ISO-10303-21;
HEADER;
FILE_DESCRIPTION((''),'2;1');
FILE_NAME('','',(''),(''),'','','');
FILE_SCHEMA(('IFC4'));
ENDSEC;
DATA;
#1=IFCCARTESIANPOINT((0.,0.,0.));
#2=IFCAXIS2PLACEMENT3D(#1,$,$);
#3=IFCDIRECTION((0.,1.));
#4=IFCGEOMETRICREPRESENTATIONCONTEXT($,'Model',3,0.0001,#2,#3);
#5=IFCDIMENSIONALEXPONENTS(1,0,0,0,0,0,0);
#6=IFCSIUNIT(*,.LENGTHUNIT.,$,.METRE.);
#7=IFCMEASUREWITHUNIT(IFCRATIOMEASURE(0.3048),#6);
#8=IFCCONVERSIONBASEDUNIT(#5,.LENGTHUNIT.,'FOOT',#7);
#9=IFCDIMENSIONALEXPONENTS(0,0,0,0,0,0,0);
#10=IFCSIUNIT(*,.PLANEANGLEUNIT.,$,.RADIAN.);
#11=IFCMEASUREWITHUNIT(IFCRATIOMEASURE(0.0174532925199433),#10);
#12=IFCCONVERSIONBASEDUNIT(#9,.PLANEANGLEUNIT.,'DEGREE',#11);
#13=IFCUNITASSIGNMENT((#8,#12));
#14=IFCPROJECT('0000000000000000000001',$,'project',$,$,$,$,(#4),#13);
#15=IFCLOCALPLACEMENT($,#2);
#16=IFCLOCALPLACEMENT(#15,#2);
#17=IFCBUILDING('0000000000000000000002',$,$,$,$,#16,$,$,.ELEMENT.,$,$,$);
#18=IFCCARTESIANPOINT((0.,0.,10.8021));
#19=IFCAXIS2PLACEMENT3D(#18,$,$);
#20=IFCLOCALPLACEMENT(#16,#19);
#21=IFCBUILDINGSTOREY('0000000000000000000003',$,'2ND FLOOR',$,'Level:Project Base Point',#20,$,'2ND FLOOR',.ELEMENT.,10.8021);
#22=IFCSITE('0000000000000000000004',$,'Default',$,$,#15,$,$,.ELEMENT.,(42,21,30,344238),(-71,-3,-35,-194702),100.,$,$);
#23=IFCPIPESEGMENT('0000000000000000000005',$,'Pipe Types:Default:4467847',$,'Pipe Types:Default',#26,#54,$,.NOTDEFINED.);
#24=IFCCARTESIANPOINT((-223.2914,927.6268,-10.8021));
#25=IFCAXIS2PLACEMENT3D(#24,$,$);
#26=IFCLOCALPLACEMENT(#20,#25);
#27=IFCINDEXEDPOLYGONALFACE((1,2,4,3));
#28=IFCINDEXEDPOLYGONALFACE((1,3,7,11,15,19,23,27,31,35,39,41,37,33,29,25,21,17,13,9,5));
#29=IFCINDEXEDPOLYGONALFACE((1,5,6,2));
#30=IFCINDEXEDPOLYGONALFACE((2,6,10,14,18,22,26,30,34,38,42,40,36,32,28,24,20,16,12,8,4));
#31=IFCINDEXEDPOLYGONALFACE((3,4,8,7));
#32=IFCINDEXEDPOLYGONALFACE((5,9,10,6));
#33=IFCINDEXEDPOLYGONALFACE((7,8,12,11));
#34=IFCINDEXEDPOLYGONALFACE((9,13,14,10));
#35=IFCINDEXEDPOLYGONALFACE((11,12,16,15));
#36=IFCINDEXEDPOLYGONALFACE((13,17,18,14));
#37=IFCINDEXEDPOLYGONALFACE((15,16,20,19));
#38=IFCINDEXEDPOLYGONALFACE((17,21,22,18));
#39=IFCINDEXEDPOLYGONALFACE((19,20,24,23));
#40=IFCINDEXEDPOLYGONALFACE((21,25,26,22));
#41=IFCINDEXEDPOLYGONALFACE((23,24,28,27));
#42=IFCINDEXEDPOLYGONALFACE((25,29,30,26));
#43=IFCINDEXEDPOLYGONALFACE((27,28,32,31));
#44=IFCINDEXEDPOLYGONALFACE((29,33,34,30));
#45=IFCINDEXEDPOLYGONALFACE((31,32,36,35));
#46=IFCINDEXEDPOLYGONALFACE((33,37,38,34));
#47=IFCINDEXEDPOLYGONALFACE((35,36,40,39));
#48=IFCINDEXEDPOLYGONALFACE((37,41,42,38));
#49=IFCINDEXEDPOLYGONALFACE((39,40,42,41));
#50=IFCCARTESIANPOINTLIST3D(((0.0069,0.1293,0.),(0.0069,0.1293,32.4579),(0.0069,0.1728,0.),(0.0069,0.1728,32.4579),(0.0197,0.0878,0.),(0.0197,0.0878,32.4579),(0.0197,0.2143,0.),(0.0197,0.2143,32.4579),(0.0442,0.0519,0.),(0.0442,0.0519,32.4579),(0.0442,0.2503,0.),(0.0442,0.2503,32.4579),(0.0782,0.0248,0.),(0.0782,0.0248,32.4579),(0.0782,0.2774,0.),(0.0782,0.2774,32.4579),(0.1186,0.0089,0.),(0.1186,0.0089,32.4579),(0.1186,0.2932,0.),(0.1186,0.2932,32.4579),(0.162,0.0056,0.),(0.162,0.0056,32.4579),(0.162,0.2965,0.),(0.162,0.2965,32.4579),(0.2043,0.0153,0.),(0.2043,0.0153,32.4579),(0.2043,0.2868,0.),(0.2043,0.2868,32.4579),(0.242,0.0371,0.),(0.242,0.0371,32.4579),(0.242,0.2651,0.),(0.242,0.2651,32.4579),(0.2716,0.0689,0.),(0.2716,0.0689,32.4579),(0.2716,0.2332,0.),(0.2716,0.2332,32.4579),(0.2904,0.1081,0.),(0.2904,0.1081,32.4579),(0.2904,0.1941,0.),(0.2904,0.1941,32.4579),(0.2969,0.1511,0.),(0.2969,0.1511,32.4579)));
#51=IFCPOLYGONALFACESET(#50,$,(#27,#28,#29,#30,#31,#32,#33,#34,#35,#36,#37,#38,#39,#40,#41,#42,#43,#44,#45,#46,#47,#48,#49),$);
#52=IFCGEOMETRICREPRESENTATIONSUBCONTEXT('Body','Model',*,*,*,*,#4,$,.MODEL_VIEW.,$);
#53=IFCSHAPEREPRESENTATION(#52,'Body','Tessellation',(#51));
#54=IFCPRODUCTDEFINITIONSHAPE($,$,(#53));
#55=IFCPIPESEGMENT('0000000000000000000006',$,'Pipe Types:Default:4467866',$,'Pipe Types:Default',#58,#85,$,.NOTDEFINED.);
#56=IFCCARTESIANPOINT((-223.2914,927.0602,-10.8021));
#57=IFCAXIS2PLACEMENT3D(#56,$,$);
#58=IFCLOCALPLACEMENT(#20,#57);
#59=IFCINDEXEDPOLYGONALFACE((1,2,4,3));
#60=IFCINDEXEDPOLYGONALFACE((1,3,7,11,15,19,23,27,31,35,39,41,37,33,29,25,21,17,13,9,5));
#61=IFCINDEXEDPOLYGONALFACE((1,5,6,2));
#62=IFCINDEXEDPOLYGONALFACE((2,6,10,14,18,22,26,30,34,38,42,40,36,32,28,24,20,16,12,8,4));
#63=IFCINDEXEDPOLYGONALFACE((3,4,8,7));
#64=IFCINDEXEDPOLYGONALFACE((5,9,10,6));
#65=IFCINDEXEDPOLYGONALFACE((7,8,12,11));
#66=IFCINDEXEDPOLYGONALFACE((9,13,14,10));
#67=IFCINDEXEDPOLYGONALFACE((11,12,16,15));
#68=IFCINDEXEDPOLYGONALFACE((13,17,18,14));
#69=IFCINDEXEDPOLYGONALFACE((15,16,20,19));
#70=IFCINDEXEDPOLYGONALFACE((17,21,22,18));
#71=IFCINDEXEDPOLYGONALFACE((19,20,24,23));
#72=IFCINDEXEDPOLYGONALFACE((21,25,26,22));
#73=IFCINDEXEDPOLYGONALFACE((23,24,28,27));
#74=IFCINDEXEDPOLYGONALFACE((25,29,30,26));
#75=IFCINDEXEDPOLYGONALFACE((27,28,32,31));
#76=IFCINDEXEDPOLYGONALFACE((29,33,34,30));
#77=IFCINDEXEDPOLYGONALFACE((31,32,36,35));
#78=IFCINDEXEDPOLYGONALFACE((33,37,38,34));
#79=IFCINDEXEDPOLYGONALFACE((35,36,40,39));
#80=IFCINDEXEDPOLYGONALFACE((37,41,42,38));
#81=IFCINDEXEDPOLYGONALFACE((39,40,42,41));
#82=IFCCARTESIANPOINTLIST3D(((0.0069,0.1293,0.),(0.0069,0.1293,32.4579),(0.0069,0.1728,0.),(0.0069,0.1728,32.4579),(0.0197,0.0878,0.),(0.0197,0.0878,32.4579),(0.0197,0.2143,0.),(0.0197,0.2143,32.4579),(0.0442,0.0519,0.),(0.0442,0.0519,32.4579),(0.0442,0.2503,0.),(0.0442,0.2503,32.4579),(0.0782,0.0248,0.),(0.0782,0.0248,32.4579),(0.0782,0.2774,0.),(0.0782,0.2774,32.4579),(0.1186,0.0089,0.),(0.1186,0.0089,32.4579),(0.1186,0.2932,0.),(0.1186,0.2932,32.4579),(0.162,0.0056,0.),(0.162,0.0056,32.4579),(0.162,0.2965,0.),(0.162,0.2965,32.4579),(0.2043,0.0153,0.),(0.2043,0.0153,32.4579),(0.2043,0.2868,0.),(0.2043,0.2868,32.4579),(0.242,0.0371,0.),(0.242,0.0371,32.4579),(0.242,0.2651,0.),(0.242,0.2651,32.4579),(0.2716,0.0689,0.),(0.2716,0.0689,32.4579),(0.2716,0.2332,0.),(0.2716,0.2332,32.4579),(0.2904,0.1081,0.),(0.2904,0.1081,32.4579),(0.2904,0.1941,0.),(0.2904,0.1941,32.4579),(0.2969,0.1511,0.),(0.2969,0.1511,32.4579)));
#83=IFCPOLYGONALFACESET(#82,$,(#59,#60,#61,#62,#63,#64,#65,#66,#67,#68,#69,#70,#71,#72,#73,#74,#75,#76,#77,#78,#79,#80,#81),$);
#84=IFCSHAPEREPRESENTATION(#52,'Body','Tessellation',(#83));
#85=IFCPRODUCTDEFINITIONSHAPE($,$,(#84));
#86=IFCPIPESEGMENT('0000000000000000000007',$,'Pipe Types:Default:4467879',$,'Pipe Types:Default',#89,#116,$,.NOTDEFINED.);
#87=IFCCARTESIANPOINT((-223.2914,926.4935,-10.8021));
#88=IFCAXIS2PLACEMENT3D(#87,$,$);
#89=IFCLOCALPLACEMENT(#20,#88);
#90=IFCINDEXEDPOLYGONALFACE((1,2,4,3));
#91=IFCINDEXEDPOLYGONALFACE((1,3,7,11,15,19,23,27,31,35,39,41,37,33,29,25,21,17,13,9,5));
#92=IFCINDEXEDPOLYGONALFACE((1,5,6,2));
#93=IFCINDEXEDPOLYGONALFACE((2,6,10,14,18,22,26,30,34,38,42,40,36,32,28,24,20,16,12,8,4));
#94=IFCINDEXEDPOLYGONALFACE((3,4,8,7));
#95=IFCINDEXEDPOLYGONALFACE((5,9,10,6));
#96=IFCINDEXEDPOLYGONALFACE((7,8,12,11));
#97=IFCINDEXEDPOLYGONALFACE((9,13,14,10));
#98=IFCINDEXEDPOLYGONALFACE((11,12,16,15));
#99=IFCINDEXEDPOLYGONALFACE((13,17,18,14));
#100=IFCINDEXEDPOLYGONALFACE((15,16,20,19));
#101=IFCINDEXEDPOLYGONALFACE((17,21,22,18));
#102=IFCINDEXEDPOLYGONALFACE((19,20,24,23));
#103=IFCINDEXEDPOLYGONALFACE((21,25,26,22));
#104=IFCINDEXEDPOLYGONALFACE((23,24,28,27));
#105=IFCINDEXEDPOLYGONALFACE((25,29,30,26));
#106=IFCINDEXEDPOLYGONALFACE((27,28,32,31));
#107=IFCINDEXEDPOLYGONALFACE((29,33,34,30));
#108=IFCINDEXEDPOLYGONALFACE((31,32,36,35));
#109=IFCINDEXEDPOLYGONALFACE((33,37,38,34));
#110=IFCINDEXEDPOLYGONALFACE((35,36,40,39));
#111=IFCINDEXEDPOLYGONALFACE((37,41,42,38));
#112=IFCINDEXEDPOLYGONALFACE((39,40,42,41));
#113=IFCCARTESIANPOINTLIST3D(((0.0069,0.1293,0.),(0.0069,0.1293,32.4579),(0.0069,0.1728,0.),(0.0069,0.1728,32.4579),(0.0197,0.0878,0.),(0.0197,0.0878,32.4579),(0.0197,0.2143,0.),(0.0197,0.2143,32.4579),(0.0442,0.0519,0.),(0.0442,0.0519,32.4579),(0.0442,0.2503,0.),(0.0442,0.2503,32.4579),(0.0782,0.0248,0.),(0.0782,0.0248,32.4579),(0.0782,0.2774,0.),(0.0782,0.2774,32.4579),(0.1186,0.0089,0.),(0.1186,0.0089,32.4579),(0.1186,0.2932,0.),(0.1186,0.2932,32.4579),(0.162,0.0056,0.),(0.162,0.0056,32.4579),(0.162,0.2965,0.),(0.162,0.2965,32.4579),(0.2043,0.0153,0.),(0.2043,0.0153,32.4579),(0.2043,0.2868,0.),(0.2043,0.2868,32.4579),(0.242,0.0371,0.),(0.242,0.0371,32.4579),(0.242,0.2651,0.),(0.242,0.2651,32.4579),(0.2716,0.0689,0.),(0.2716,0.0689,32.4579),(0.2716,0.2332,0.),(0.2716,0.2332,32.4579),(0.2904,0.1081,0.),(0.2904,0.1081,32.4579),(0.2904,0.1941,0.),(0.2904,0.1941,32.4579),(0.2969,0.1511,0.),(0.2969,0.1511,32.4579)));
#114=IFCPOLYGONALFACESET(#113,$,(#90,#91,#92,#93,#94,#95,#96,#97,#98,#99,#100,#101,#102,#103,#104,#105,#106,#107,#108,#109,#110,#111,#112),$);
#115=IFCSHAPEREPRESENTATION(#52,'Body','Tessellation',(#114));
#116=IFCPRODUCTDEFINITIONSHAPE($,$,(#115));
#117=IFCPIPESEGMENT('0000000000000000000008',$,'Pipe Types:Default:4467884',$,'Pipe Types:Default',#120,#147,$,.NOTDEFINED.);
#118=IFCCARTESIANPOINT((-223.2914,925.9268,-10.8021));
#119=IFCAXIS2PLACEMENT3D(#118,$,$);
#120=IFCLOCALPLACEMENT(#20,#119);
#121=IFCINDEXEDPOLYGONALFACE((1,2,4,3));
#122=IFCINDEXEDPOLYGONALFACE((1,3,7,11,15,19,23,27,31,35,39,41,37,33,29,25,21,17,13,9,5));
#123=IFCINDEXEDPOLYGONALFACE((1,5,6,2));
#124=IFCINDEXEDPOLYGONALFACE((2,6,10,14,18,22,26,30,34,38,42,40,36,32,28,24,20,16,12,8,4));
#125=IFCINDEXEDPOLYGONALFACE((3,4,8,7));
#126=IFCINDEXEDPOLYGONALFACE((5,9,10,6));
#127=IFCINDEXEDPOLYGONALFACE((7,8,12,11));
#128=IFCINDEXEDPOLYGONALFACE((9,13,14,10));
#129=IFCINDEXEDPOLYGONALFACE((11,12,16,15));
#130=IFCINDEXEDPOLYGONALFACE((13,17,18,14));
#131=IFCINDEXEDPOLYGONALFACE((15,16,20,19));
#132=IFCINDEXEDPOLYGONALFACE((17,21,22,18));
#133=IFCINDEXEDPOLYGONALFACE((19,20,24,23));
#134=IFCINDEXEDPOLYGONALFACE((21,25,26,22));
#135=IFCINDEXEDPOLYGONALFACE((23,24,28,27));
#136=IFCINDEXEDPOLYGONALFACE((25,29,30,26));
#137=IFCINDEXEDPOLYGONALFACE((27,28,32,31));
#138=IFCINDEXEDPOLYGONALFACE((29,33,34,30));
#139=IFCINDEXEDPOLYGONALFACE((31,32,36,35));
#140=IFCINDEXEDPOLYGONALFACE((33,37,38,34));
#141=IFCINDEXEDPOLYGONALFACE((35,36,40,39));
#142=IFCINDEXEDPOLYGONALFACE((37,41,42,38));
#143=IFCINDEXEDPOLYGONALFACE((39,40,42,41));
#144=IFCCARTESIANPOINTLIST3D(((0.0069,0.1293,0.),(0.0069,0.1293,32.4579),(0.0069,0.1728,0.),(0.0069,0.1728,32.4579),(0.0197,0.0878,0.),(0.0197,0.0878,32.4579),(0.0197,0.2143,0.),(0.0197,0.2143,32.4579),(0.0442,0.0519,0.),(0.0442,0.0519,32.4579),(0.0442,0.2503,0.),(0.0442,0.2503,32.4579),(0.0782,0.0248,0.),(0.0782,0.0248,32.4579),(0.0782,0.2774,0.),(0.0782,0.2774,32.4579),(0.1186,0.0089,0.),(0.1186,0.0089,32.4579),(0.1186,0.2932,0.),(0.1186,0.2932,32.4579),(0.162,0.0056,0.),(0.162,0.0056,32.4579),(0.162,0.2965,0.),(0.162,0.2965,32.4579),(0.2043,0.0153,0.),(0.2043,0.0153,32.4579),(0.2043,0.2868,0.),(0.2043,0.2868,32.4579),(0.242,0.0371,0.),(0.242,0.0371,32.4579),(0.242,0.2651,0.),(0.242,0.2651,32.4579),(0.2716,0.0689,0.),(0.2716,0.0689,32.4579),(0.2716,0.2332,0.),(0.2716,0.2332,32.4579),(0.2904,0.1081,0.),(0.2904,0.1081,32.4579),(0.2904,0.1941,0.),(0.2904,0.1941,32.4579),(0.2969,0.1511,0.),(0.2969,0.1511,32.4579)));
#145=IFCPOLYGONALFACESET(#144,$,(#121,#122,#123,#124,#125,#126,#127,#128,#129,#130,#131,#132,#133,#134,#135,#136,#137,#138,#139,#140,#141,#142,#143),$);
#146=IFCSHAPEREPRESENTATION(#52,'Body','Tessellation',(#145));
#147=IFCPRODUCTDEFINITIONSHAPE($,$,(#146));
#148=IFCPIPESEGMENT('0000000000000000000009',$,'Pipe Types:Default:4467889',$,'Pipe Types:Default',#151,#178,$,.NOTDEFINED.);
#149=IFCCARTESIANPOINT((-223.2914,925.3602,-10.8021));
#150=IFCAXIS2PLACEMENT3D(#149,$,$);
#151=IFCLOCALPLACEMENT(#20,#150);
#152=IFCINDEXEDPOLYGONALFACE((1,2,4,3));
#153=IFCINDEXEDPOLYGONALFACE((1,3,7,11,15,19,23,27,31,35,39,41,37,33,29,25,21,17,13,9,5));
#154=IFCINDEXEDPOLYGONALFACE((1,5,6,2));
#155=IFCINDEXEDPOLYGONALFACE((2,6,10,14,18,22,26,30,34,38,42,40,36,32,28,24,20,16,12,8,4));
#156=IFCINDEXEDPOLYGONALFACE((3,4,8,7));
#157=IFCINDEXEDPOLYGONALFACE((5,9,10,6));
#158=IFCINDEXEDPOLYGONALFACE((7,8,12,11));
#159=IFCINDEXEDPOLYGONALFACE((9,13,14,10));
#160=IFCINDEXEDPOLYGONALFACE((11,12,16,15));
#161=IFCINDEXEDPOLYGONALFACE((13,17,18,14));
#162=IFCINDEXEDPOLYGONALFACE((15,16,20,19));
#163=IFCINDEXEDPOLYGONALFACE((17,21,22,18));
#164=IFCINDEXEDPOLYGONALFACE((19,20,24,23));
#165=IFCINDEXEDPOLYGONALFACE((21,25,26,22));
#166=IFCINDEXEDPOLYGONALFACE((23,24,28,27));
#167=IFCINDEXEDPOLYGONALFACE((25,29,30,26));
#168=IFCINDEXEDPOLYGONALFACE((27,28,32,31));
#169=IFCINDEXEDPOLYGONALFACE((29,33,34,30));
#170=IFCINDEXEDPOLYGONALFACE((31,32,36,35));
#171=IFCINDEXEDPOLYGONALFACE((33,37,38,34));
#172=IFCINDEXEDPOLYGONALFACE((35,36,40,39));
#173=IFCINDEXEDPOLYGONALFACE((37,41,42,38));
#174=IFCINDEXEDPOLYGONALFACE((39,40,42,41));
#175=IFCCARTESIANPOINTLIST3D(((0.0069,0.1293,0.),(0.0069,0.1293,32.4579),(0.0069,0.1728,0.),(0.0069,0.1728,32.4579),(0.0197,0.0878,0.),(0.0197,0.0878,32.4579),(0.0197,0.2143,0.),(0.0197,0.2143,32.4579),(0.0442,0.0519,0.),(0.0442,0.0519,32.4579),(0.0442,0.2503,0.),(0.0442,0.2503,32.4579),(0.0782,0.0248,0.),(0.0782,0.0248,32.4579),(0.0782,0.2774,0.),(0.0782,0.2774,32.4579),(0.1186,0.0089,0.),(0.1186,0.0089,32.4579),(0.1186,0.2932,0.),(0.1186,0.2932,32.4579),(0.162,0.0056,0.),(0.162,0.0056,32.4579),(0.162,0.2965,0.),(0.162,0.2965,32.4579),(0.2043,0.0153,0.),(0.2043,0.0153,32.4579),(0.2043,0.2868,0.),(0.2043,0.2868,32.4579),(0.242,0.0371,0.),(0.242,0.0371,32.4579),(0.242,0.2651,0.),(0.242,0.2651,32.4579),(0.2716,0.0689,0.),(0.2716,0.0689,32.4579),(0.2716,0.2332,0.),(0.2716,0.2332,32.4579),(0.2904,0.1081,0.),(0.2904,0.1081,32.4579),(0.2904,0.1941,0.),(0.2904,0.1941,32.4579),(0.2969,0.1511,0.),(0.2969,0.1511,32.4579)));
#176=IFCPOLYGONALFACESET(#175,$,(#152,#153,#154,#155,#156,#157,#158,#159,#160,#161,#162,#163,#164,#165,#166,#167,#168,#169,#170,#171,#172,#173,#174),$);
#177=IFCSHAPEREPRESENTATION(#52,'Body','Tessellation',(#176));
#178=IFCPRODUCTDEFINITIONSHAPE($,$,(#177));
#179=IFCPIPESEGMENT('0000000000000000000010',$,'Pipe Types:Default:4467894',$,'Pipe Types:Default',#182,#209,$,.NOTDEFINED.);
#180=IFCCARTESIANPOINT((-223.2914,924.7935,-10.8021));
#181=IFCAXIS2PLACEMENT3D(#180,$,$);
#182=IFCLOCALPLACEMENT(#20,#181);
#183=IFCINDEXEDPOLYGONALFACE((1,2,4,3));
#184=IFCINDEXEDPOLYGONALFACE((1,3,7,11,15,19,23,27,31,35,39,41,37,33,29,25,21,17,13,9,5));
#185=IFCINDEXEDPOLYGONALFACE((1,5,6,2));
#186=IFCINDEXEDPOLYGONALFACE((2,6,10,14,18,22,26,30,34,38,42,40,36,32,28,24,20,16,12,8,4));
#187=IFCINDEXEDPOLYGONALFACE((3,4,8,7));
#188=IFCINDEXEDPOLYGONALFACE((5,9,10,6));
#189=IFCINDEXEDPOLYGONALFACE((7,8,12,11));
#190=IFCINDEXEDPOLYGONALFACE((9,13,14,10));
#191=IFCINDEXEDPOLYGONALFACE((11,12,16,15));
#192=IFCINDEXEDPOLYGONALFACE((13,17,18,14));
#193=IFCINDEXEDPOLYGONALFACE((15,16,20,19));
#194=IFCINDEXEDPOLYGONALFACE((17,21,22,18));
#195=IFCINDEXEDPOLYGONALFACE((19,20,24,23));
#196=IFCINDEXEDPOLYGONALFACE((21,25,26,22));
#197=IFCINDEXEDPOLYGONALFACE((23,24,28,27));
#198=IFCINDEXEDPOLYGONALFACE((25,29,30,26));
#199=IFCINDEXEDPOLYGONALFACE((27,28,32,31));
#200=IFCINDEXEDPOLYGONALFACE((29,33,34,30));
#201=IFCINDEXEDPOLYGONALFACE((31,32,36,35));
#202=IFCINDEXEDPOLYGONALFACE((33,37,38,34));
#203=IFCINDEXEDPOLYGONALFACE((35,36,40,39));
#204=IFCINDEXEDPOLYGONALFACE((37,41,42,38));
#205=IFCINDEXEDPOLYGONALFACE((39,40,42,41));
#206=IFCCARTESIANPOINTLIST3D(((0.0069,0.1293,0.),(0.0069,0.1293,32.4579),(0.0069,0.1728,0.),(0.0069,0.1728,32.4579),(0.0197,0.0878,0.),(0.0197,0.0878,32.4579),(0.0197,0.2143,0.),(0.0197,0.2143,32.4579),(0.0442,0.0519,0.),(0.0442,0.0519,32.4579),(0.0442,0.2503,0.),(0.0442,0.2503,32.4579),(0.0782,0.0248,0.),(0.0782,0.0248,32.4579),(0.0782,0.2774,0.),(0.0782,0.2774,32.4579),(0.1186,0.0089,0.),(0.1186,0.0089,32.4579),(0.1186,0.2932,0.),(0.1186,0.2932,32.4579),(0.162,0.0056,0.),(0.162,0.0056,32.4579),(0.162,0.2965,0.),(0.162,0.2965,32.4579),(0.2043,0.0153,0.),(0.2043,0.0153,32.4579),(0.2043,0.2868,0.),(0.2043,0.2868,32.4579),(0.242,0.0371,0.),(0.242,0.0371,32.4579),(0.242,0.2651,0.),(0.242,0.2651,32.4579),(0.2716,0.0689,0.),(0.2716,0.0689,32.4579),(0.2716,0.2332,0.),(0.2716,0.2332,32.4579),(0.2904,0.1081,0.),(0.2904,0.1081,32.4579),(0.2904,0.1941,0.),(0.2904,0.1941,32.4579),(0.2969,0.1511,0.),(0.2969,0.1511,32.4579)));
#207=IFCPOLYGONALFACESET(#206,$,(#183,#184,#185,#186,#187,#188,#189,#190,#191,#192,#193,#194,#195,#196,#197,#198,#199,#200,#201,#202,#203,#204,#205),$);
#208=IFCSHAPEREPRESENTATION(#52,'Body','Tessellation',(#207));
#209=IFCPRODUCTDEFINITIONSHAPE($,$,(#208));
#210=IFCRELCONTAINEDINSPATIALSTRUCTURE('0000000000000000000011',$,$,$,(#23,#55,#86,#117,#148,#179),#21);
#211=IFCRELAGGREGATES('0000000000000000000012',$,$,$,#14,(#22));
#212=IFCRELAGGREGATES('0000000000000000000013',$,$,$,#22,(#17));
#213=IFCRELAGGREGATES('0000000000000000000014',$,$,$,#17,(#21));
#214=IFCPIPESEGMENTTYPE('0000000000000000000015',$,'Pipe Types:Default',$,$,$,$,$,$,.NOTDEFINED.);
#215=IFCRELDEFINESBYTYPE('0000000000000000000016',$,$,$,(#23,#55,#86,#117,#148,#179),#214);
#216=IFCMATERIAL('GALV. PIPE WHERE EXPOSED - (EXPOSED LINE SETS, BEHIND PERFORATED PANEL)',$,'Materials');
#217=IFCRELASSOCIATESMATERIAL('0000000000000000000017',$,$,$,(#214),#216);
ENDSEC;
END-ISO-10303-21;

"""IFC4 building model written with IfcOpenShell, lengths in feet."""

from ifc_helpers import new_model, entity, si_unit, converted_unit, direction, frame, frame_2d, origin, origin_2d_with_axis, place, context, subcontext, project, spatial, circle, extrude, material, type_object, element, save


model = new_model("IFC4")

# Units and contexts
model_context = context("Model", 3, precision=0.0001, world=origin(), true_north=direction((0.0, 1.0)))
body_context = subcontext(model_context, "Body", "Model", "MODEL_VIEW")
ifc_project = project(units=[converted_unit("LENGTHUNIT", "FOOT", entity("IfcRatioMeasure", 0.3048), si_unit("LENGTHUNIT", "METRE"), dimensions=[1, 0, 0, 0, 0, 0, 0]), converted_unit("PLANEANGLEUNIT", "DEGREE", entity("IfcRatioMeasure", 0.0174532925199433), si_unit("PLANEANGLEUNIT", "RADIAN"), dimensions=[0, 0, 0, 0, 0, 0, 0])], contexts=[model_context])

# Site, building, storey
site_placement = place(None, origin())
site = spatial("IfcSite", under=ifc_project, at=site_placement, Name="Default", CompositionType="ELEMENT", RefLatitude=(42, 21, 30, 344238), RefLongitude=(-71, -3, -35, -194702), RefElevation=100.0)
building_placement = place(site_placement, origin())
building = spatial("IfcBuilding", under=site, at=building_placement, CompositionType="ELEMENT")
storey_placement = place(building_placement, frame((0.0, 0.0, 10.8021)))
storey = spatial("IfcBuildingStorey", under=building, at=storey_placement, Name="2ND FLOOR", ObjectType="Level:Project Base Point", LongName="2ND FLOOR", CompositionType="ELEMENT", Elevation=10.8021)

# Pipe segments
ifc_material_1 = material(Name="GALV. PIPE WHERE EXPOSED - (EXPOSED LINE SETS, BEHIND PERFORATED PANEL)", Category="Materials")
pipe_segment_type = type_object("IfcPipeSegmentType", Name="Pipe Types:Default", PredefinedType="NOTDEFINED", material=ifc_material_1)
pipe_segment_1_placement = place(storey_placement, frame((-223.2914, 927.6268, -10.8021)))
element("IfcPipeSegment", 1, at=pipe_segment_1_placement, inside=storey, type_object=pipe_segment_type, Name="Pipe Types:Default:4467847", ObjectType="Pipe Types:Default", PredefinedType="NOTDEFINED", context=body_context, shape_type="SweptSolid", body=[
    extrude(circle(Radius=0.1458, at=frame_2d((0.0, 0.0), x_axis=(1.0, 0.0))), frame((0.1511, 0.1511, 0.0)), (0.0, 0.0, 1.0), 32.4579),
])
for number, where, name in (
    (2, (-223.2914, 927.0602, -10.8021), "Pipe Types:Default:4467866"),
    (3, (-223.2914, 926.4935, -10.8021), "Pipe Types:Default:4467879"),
):
    element("IfcPipeSegment", number, at=place(storey_placement, frame(where)), inside=storey, type_object=pipe_segment_type, Name=name, ObjectType="Pipe Types:Default", PredefinedType="NOTDEFINED", context=body_context, shape_type="SweptSolid", body=[
        extrude(circle(Radius=0.1458, at=origin_2d_with_axis()), frame((0.1511, 0.1511, 0.0)), (0.0, 0.0, 1.0), 32.4579),
    ])
pipe_segment_2_placement = place(storey_placement, frame((-223.2914, 925.9268, -10.8021)))
element("IfcPipeSegment", 4, at=pipe_segment_2_placement, inside=storey, type_object=pipe_segment_type, Name="Pipe Types:Default:4467884", ObjectType="Pipe Types:Default", PredefinedType="NOTDEFINED", context=body_context, shape_type="SweptSolid", body=[
    extrude(circle(Radius=0.1458, at=frame_2d((0.0, 0.0), x_axis=(1.0, 0.0))), frame((0.1511, 0.1511, 0.0)), (0.0, 0.0, 1.0), 32.4579),
])
for number, where, name in (
    (5, (-223.2914, 925.3602, -10.8021), "Pipe Types:Default:4467889"),
    (6, (-223.2914, 924.7935, -10.8021), "Pipe Types:Default:4467894"),
):
    element("IfcPipeSegment", number, at=place(storey_placement, frame(where)), inside=storey, type_object=pipe_segment_type, Name=name, ObjectType="Pipe Types:Default", PredefinedType="NOTDEFINED", context=body_context, shape_type="SweptSolid", body=[
        extrude(circle(Radius=0.1458, at=origin_2d_with_axis()), frame((0.1511, 0.1511, 0.0)), (0.0, 0.0, 1.0), 32.4579),
    ])

save(model, "model.ifc")
